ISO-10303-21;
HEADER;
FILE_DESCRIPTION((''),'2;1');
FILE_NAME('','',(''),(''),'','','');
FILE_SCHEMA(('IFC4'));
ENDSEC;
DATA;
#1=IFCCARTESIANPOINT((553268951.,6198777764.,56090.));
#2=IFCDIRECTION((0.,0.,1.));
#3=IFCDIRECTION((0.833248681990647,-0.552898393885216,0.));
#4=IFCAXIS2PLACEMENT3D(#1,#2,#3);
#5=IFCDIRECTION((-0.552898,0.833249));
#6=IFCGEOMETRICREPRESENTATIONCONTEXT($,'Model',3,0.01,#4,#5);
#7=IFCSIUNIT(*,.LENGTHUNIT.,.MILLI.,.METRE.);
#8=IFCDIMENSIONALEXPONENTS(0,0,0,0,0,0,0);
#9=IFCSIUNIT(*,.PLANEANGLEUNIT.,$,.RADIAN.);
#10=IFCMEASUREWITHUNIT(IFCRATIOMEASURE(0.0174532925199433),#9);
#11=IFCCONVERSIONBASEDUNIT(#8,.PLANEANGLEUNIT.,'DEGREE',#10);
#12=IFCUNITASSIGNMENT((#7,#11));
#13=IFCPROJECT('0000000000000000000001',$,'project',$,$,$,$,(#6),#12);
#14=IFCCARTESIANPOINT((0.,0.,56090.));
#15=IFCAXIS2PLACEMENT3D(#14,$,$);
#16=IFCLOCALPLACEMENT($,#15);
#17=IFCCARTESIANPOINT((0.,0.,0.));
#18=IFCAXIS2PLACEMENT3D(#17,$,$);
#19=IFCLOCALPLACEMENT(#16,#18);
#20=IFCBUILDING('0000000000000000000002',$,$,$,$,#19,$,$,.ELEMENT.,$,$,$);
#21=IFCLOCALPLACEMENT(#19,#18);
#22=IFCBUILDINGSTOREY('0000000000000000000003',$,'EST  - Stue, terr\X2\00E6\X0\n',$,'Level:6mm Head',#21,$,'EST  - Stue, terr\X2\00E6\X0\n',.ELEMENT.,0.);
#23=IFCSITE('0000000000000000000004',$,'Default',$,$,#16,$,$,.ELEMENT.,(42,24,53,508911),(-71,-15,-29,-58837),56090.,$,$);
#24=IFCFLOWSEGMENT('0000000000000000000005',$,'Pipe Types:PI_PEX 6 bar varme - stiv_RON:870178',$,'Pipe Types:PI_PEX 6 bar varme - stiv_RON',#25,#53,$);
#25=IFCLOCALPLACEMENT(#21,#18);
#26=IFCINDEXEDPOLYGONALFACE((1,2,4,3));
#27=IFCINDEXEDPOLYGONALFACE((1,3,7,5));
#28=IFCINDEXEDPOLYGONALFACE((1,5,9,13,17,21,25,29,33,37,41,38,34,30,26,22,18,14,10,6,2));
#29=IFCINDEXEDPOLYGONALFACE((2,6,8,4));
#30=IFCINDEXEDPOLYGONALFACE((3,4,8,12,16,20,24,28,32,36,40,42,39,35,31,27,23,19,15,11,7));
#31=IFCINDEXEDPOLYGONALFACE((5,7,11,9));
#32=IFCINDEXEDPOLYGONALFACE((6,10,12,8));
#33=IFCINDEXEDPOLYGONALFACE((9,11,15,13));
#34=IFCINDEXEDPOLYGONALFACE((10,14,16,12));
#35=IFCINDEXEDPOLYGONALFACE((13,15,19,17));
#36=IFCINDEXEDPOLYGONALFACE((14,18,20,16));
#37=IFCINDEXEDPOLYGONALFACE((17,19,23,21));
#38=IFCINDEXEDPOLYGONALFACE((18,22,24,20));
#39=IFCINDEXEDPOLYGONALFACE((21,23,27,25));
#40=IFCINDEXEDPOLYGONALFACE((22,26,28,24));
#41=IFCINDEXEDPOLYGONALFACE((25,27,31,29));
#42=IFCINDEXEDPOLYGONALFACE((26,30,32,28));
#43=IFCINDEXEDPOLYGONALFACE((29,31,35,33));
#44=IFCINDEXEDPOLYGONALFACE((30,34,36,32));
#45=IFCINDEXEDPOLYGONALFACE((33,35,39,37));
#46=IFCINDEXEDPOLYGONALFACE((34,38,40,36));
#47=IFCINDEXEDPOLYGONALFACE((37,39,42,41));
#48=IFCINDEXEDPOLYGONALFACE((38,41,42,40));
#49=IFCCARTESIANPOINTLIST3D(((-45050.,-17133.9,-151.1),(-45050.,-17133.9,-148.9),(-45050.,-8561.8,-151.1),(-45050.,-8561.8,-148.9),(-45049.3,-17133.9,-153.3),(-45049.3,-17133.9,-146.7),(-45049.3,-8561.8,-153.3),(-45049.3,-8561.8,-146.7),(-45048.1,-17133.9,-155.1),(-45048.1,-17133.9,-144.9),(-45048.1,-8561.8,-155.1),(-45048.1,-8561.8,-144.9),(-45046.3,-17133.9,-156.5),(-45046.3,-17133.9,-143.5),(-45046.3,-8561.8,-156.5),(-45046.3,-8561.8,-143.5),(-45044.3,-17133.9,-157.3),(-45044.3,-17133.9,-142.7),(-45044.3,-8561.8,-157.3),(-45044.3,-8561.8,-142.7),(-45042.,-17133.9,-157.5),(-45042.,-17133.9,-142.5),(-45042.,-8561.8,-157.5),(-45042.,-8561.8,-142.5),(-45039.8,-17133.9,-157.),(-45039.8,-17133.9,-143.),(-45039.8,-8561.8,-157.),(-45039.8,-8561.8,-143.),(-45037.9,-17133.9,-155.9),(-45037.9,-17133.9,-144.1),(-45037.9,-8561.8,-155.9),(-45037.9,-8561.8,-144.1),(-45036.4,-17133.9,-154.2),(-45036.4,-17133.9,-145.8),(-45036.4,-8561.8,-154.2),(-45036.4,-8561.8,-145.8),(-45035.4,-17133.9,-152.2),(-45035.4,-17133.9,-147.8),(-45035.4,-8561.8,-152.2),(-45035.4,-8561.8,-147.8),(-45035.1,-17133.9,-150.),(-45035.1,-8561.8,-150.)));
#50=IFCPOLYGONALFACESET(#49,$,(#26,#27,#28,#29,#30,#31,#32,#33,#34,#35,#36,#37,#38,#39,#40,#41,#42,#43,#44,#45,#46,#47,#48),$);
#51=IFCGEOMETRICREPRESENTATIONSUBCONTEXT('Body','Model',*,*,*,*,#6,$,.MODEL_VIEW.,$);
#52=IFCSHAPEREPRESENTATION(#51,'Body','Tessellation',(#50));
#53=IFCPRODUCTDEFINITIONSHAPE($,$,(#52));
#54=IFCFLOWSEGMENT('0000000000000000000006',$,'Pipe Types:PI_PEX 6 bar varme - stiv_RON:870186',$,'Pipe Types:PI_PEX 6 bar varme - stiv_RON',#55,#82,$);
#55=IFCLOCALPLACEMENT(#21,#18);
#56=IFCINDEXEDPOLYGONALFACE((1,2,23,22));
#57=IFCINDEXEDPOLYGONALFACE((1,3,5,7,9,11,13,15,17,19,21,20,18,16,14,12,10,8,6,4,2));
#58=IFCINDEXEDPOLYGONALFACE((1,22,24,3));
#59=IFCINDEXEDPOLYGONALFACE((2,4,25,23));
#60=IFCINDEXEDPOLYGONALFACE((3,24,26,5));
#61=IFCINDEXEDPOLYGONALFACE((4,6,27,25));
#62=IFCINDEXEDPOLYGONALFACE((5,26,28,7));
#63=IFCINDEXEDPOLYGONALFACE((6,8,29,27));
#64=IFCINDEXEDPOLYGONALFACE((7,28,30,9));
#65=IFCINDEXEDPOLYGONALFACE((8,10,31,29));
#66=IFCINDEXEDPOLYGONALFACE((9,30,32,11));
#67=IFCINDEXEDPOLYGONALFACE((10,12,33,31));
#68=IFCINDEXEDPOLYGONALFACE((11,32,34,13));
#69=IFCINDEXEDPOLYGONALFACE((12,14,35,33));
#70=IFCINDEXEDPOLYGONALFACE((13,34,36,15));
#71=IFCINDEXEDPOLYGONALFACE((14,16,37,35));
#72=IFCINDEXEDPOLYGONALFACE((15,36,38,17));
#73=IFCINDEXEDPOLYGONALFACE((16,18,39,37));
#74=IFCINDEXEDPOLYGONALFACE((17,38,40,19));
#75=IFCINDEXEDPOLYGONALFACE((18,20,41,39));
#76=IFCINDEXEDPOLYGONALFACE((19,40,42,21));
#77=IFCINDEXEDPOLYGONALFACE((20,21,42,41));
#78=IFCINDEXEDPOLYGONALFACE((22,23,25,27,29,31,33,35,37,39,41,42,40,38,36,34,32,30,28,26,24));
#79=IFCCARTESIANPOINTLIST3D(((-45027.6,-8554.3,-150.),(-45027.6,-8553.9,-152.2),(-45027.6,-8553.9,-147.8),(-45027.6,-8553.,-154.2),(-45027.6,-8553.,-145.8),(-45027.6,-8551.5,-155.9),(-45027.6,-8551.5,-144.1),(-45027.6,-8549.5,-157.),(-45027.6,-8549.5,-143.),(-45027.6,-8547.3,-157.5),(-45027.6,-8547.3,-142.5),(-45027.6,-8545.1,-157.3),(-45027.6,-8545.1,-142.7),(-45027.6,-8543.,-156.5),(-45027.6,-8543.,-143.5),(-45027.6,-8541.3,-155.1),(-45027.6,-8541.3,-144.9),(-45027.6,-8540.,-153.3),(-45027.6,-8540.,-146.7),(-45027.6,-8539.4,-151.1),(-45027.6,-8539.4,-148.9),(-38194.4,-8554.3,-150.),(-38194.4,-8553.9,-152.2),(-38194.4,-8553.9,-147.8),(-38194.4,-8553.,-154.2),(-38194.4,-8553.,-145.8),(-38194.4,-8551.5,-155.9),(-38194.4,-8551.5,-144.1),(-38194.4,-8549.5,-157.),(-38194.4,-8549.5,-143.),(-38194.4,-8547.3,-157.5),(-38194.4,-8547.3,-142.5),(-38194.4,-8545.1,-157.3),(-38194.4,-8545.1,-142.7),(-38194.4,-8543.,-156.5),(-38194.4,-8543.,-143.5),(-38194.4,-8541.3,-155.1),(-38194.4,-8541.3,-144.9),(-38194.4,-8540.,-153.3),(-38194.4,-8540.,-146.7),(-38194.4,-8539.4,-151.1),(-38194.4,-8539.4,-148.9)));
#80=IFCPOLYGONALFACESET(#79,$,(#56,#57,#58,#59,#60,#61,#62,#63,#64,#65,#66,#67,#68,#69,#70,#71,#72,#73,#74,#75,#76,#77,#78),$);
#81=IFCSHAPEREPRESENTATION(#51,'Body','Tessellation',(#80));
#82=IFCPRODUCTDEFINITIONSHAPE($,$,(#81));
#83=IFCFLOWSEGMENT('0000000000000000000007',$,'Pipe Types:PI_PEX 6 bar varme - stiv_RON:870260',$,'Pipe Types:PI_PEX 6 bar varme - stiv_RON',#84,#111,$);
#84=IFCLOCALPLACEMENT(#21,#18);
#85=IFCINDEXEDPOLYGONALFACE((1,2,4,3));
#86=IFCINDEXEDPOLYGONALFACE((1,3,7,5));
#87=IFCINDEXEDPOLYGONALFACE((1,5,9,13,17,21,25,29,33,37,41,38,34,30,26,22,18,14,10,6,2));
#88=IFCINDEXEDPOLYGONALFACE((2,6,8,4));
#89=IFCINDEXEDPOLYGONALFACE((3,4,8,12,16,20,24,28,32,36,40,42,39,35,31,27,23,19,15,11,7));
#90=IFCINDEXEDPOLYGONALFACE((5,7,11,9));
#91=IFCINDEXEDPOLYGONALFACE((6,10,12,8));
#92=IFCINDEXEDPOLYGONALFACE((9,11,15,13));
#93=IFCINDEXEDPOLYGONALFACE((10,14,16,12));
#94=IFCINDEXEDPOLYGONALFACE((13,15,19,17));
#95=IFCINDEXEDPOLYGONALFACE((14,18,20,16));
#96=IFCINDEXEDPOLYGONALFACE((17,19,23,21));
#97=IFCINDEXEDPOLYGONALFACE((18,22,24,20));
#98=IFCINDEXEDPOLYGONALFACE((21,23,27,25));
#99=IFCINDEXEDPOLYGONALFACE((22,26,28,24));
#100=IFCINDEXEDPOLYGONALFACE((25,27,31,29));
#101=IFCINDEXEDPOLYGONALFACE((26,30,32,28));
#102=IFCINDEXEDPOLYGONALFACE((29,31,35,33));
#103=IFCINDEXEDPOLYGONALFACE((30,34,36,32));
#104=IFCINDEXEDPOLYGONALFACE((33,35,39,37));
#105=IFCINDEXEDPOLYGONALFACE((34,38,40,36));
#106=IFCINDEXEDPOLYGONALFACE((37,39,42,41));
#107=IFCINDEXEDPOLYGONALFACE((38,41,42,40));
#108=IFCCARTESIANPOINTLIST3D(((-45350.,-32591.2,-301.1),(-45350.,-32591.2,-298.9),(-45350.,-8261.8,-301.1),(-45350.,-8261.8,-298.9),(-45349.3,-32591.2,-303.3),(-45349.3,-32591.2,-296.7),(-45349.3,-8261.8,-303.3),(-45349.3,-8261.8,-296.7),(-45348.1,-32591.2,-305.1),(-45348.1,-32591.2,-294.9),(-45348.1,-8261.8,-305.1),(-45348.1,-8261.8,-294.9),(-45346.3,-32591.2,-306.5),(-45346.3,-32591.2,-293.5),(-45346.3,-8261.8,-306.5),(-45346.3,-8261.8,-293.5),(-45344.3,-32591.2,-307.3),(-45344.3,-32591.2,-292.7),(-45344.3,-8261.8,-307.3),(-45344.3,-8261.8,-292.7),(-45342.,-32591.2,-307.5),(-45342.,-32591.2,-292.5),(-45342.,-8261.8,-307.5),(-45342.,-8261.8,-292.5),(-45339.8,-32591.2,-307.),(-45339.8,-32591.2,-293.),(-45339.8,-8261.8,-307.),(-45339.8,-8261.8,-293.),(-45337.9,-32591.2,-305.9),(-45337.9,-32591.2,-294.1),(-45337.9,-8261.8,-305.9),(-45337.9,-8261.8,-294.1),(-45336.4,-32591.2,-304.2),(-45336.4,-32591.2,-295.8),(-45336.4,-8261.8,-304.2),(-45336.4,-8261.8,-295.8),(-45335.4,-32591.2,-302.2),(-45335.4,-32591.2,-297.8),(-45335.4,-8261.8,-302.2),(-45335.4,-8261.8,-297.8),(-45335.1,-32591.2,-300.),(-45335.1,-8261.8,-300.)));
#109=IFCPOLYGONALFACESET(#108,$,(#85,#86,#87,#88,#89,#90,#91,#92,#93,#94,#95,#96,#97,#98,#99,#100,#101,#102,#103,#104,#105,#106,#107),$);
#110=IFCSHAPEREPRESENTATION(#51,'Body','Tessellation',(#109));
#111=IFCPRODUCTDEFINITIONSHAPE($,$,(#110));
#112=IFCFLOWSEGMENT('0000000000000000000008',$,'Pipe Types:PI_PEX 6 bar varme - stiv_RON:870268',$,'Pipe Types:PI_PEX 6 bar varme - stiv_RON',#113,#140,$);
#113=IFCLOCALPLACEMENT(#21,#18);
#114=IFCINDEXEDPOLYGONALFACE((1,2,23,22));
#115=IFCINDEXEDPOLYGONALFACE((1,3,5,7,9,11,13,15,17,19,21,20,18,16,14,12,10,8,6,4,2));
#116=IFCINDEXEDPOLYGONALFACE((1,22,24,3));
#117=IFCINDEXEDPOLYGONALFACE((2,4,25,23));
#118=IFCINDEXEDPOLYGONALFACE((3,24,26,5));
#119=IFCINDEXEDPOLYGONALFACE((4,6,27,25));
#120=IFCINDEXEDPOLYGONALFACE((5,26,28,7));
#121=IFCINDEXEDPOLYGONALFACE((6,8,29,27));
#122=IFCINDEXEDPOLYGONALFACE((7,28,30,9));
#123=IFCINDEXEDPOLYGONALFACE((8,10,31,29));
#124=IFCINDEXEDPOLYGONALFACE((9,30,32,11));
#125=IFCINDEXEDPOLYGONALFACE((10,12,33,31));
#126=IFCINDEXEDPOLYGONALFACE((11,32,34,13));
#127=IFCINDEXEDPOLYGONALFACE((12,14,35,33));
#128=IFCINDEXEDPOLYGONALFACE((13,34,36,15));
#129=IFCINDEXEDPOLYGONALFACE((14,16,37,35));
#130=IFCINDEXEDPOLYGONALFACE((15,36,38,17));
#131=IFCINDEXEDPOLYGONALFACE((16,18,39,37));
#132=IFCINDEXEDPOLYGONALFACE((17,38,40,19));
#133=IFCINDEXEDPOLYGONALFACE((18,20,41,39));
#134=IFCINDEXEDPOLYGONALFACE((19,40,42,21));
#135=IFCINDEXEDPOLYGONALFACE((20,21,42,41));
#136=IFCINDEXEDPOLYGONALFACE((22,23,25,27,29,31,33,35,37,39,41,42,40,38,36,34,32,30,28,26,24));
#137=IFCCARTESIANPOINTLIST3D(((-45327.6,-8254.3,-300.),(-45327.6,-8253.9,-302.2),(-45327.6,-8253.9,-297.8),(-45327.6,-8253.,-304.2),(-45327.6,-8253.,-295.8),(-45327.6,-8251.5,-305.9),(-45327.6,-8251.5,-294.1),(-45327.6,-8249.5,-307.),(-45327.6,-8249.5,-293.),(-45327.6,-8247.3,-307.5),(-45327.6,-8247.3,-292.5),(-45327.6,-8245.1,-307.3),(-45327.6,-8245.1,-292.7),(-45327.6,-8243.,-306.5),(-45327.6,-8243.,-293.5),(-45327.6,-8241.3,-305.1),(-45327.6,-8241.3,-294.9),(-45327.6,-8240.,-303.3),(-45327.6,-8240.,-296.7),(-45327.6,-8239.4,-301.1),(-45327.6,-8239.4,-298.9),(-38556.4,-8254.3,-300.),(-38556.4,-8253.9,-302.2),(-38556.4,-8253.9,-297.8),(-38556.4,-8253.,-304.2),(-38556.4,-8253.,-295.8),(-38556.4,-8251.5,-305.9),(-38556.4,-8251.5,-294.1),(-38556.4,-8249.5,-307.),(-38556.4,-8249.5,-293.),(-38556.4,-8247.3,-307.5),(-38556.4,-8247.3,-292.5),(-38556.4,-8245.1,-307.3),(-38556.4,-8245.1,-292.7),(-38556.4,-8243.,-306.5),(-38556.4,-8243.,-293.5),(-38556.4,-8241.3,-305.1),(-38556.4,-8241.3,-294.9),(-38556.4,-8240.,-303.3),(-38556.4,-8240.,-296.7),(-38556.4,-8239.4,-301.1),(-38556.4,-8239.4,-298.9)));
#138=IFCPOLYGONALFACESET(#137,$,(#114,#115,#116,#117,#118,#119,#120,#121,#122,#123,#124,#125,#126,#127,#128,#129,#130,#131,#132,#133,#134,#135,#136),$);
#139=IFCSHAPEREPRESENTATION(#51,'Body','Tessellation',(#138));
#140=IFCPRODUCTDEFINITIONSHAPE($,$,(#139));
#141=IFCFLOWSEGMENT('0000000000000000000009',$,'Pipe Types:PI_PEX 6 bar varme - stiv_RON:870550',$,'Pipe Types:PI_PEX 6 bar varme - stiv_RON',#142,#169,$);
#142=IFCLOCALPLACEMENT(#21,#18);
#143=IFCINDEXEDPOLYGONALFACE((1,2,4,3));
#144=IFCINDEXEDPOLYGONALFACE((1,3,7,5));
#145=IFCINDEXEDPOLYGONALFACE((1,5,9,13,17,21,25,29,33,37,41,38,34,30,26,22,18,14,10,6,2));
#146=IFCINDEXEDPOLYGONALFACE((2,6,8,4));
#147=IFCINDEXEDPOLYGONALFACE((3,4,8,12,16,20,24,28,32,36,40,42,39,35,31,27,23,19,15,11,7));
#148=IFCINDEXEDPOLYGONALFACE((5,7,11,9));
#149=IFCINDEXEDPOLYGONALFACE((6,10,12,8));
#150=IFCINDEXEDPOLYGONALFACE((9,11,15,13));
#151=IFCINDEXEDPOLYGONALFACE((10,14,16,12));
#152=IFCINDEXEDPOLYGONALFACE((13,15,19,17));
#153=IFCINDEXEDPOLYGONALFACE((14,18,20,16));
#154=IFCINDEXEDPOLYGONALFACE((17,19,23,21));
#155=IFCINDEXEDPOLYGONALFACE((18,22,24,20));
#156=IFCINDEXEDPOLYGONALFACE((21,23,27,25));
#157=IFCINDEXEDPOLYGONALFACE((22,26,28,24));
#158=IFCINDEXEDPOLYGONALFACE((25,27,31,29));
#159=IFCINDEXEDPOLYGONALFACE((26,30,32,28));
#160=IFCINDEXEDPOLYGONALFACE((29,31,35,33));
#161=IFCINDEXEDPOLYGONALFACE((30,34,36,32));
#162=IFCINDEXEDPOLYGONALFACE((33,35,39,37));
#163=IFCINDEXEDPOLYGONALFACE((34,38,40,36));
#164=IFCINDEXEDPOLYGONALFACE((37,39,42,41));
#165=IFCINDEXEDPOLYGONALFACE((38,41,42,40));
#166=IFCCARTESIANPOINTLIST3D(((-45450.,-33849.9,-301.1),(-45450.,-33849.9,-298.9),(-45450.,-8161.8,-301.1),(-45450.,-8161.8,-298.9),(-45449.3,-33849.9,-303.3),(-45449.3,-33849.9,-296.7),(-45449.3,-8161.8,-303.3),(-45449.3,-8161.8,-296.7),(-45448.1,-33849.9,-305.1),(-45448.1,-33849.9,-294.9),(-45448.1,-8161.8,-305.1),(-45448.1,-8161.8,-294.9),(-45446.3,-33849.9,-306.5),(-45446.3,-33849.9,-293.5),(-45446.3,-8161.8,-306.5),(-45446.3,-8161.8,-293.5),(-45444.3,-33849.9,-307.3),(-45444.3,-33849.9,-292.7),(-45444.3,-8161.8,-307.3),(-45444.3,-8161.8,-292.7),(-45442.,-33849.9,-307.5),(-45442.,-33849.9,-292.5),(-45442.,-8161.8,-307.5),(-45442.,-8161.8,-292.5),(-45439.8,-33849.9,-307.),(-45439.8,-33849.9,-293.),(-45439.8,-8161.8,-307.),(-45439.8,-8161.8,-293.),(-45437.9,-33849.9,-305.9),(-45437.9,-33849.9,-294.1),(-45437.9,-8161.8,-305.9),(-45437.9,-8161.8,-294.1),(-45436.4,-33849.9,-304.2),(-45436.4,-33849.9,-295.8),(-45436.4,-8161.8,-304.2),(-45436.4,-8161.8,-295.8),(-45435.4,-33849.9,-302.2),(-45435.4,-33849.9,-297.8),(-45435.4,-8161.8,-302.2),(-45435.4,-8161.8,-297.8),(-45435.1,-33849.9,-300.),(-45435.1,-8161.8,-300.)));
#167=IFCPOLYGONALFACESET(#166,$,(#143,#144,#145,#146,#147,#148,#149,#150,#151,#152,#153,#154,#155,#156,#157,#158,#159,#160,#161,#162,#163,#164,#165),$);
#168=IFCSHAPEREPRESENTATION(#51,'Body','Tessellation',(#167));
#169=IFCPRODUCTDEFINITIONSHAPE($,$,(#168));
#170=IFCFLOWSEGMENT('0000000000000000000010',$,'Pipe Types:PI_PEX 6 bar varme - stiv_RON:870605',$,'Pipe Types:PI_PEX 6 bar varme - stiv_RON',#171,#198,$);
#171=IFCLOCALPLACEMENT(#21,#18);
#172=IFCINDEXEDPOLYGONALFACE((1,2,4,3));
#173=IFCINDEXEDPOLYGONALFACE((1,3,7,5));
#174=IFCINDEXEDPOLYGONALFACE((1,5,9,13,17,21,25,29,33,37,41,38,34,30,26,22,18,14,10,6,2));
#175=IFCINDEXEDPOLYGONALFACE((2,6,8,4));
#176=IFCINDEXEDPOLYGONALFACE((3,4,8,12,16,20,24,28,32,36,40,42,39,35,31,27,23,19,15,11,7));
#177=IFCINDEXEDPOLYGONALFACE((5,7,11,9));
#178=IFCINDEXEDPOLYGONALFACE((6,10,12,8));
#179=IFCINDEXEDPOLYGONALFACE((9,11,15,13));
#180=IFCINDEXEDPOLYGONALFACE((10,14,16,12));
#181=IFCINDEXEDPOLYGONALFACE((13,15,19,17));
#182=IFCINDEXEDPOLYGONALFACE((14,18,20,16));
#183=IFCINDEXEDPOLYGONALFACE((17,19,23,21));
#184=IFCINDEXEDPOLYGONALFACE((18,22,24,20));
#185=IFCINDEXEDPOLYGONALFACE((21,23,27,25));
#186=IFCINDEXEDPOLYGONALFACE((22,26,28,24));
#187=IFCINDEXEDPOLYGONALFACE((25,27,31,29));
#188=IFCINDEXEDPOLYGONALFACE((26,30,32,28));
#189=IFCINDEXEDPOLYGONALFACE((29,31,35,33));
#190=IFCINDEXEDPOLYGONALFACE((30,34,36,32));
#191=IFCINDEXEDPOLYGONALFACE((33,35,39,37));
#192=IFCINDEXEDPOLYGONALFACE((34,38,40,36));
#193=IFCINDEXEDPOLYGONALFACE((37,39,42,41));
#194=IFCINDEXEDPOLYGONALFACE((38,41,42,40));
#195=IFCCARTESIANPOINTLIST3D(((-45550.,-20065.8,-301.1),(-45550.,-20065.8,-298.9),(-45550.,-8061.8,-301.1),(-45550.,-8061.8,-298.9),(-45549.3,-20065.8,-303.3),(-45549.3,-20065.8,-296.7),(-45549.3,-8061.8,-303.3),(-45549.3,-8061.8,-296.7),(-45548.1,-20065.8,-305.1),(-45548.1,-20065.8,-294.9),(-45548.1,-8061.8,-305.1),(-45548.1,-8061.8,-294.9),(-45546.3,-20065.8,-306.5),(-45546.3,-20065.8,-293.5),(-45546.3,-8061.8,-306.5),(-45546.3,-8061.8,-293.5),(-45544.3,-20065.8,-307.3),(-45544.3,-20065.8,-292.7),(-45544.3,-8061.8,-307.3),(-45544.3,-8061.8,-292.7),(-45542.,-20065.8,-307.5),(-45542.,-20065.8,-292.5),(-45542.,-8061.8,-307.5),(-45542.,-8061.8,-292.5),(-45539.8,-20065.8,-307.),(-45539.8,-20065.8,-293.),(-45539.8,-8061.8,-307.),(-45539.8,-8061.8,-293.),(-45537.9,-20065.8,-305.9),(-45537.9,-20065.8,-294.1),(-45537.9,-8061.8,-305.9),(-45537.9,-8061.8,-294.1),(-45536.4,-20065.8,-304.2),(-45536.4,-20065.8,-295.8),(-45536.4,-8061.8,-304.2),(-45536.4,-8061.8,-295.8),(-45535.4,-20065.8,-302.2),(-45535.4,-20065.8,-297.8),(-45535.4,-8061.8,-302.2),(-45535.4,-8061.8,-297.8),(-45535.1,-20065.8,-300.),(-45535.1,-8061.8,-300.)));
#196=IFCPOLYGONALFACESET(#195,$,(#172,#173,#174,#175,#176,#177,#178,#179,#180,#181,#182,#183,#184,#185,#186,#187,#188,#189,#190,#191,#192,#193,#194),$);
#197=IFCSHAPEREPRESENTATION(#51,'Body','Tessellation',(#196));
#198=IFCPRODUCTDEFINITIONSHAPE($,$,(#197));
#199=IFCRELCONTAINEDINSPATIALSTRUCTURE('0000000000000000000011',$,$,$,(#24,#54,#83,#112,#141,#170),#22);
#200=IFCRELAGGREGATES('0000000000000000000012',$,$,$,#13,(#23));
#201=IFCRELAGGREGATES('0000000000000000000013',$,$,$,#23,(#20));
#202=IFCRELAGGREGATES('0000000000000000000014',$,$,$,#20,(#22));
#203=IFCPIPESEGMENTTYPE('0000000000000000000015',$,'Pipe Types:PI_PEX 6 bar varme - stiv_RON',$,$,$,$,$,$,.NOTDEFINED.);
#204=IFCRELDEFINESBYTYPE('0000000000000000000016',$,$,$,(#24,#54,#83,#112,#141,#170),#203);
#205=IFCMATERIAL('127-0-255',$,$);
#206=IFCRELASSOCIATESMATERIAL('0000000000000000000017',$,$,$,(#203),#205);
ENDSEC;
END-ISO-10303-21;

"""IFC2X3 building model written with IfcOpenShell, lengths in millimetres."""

from ifc_helpers import new_model, entity, si_unit, converted_unit, direction, frame, origin, origin_2d_with_axis, place, context, subcontext, project, spatial, circle, extrude, material, type_object, element, save


model = new_model("IFC2X3")

# Units and contexts
model_context = context("Model", 3, precision=0.01, world=frame((553268951.0, 6198777764.0, 56090.0), z_axis=(0.0, 0.0, 1.0), x_axis=(0.833248681990647, -0.552898393885216, 0.0)), true_north=direction((-0.552898, 0.833249)))
body_context = subcontext(model_context, "Body", "Model", "MODEL_VIEW")
ifc_project = project(units=[si_unit("LENGTHUNIT", "METRE", prefix="MILLI"), converted_unit("PLANEANGLEUNIT", "DEGREE", entity("IfcRatioMeasure", 0.0174532925199433), si_unit("PLANEANGLEUNIT", "RADIAN"), dimensions=[0, 0, 0, 0, 0, 0, 0])], contexts=[model_context])

# Site, building, storey
site_placement = place(None, frame((0.0, 0.0, 56090.0)))
site = spatial("IfcSite", under=ifc_project, at=site_placement, Name="Default", CompositionType="ELEMENT", RefLatitude=(42, 24, 53, 508911), RefLongitude=(-71, -15, -29, -58837), RefElevation=56090.0)
building_placement = place(site_placement, origin())
building = spatial("IfcBuilding", under=site, at=building_placement, CompositionType="ELEMENT")
storey_placement = place(building_placement, frame((0.0, 0.0, 0.0)))
storey = spatial("IfcBuildingStorey", under=building, at=storey_placement, Name="EST  - Stue, terræn", ObjectType="Level:6mm Head", LongName="EST  - Stue, terræn", CompositionType="ELEMENT", Elevation=0.0)

# Flow segments
ifc_material = material(Name="127-0-255")
pipe_segment_type = type_object("IfcPipeSegmentType", Name="Pipe Types:PI_PEX 6 bar varme - stiv_RON", PredefinedType="NOTDEFINED", material=ifc_material)
flow_segment_1_placement = place(storey_placement, origin())
element("IfcFlowSegment", 1, at=flow_segment_1_placement, inside=storey, type_object=pipe_segment_type, Name="Pipe Types:PI_PEX 6 bar varme - stiv_RON:870178", ObjectType="Pipe Types:PI_PEX 6 bar varme - stiv_RON", context=body_context, shape_type="SweptSolid", body=[
    extrude(circle(Radius=7.5, at=origin_2d_with_axis()), frame((-45042.6, -17133.9, -150.0), z_axis=(0.0, 1.0, 0.0), x_axis=(1.0, 0.0, 0.0)), (0.0, 0.0, 1.0), 8572.1),
])
flow_segment_2_placement = place(storey_placement, origin())
element("IfcFlowSegment", 2, at=flow_segment_2_placement, inside=storey, type_object=pipe_segment_type, Name="Pipe Types:PI_PEX 6 bar varme - stiv_RON:870186", ObjectType="Pipe Types:PI_PEX 6 bar varme - stiv_RON", context=body_context, shape_type="SweptSolid", body=[
    extrude(circle(Radius=7.5, at=origin_2d_with_axis()), frame((-45027.6, -8546.8, -150.0), z_axis=(1.0, 0.0, 0.0), x_axis=(0.0, -1.0, 0.0)), (0.0, 0.0, 1.0), 6833.2),
])
flow_segment_3_placement = place(storey_placement, origin())
element("IfcFlowSegment", 3, at=flow_segment_3_placement, inside=storey, type_object=pipe_segment_type, Name="Pipe Types:PI_PEX 6 bar varme - stiv_RON:870260", ObjectType="Pipe Types:PI_PEX 6 bar varme - stiv_RON", context=body_context, shape_type="SweptSolid", body=[
    extrude(circle(Radius=7.5, at=origin_2d_with_axis()), frame((-45342.6, -32591.2, -300.0), z_axis=(0.0, 1.0, 0.0), x_axis=(1.0, 0.0, 0.0)), (0.0, 0.0, 1.0), 24329.5),
])
flow_segment_4_placement = place(storey_placement, origin())
element("IfcFlowSegment", 4, at=flow_segment_4_placement, inside=storey, type_object=pipe_segment_type, Name="Pipe Types:PI_PEX 6 bar varme - stiv_RON:870268", ObjectType="Pipe Types:PI_PEX 6 bar varme - stiv_RON", context=body_context, shape_type="SweptSolid", body=[
    extrude(circle(Radius=7.5, at=origin_2d_with_axis()), frame((-45327.6, -8246.8, -300.0), z_axis=(1.0, 0.0, 0.0), x_axis=(0.0, -1.0, 0.0)), (0.0, 0.0, 1.0), 6771.2),
])
flow_segment_5_placement = place(storey_placement, origin())
element("IfcFlowSegment", 5, at=flow_segment_5_placement, inside=storey, type_object=pipe_segment_type, Name="Pipe Types:PI_PEX 6 bar varme - stiv_RON:870550", ObjectType="Pipe Types:PI_PEX 6 bar varme - stiv_RON", context=body_context, shape_type="SweptSolid", body=[
    extrude(circle(Radius=7.5, at=origin_2d_with_axis()), frame((-45442.6, -33849.9, -300.0), z_axis=(0.0, 1.0, 0.0), x_axis=(1.0, 0.0, 0.0)), (0.0, 0.0, 1.0), 25688.1),
])
flow_segment_6_placement = place(storey_placement, origin())
element("IfcFlowSegment", 6, at=flow_segment_6_placement, inside=storey, type_object=pipe_segment_type, Name="Pipe Types:PI_PEX 6 bar varme - stiv_RON:870605", ObjectType="Pipe Types:PI_PEX 6 bar varme - stiv_RON", context=body_context, shape_type="SweptSolid", body=[
    extrude(circle(Radius=7.5, at=origin_2d_with_axis()), frame((-45542.6, -20065.8, -300.0), z_axis=(0.0, 1.0, 0.0), x_axis=(1.0, 0.0, 0.0)), (0.0, 0.0, 1.0), 12004.0),
])

save(model, "model.ifc")
